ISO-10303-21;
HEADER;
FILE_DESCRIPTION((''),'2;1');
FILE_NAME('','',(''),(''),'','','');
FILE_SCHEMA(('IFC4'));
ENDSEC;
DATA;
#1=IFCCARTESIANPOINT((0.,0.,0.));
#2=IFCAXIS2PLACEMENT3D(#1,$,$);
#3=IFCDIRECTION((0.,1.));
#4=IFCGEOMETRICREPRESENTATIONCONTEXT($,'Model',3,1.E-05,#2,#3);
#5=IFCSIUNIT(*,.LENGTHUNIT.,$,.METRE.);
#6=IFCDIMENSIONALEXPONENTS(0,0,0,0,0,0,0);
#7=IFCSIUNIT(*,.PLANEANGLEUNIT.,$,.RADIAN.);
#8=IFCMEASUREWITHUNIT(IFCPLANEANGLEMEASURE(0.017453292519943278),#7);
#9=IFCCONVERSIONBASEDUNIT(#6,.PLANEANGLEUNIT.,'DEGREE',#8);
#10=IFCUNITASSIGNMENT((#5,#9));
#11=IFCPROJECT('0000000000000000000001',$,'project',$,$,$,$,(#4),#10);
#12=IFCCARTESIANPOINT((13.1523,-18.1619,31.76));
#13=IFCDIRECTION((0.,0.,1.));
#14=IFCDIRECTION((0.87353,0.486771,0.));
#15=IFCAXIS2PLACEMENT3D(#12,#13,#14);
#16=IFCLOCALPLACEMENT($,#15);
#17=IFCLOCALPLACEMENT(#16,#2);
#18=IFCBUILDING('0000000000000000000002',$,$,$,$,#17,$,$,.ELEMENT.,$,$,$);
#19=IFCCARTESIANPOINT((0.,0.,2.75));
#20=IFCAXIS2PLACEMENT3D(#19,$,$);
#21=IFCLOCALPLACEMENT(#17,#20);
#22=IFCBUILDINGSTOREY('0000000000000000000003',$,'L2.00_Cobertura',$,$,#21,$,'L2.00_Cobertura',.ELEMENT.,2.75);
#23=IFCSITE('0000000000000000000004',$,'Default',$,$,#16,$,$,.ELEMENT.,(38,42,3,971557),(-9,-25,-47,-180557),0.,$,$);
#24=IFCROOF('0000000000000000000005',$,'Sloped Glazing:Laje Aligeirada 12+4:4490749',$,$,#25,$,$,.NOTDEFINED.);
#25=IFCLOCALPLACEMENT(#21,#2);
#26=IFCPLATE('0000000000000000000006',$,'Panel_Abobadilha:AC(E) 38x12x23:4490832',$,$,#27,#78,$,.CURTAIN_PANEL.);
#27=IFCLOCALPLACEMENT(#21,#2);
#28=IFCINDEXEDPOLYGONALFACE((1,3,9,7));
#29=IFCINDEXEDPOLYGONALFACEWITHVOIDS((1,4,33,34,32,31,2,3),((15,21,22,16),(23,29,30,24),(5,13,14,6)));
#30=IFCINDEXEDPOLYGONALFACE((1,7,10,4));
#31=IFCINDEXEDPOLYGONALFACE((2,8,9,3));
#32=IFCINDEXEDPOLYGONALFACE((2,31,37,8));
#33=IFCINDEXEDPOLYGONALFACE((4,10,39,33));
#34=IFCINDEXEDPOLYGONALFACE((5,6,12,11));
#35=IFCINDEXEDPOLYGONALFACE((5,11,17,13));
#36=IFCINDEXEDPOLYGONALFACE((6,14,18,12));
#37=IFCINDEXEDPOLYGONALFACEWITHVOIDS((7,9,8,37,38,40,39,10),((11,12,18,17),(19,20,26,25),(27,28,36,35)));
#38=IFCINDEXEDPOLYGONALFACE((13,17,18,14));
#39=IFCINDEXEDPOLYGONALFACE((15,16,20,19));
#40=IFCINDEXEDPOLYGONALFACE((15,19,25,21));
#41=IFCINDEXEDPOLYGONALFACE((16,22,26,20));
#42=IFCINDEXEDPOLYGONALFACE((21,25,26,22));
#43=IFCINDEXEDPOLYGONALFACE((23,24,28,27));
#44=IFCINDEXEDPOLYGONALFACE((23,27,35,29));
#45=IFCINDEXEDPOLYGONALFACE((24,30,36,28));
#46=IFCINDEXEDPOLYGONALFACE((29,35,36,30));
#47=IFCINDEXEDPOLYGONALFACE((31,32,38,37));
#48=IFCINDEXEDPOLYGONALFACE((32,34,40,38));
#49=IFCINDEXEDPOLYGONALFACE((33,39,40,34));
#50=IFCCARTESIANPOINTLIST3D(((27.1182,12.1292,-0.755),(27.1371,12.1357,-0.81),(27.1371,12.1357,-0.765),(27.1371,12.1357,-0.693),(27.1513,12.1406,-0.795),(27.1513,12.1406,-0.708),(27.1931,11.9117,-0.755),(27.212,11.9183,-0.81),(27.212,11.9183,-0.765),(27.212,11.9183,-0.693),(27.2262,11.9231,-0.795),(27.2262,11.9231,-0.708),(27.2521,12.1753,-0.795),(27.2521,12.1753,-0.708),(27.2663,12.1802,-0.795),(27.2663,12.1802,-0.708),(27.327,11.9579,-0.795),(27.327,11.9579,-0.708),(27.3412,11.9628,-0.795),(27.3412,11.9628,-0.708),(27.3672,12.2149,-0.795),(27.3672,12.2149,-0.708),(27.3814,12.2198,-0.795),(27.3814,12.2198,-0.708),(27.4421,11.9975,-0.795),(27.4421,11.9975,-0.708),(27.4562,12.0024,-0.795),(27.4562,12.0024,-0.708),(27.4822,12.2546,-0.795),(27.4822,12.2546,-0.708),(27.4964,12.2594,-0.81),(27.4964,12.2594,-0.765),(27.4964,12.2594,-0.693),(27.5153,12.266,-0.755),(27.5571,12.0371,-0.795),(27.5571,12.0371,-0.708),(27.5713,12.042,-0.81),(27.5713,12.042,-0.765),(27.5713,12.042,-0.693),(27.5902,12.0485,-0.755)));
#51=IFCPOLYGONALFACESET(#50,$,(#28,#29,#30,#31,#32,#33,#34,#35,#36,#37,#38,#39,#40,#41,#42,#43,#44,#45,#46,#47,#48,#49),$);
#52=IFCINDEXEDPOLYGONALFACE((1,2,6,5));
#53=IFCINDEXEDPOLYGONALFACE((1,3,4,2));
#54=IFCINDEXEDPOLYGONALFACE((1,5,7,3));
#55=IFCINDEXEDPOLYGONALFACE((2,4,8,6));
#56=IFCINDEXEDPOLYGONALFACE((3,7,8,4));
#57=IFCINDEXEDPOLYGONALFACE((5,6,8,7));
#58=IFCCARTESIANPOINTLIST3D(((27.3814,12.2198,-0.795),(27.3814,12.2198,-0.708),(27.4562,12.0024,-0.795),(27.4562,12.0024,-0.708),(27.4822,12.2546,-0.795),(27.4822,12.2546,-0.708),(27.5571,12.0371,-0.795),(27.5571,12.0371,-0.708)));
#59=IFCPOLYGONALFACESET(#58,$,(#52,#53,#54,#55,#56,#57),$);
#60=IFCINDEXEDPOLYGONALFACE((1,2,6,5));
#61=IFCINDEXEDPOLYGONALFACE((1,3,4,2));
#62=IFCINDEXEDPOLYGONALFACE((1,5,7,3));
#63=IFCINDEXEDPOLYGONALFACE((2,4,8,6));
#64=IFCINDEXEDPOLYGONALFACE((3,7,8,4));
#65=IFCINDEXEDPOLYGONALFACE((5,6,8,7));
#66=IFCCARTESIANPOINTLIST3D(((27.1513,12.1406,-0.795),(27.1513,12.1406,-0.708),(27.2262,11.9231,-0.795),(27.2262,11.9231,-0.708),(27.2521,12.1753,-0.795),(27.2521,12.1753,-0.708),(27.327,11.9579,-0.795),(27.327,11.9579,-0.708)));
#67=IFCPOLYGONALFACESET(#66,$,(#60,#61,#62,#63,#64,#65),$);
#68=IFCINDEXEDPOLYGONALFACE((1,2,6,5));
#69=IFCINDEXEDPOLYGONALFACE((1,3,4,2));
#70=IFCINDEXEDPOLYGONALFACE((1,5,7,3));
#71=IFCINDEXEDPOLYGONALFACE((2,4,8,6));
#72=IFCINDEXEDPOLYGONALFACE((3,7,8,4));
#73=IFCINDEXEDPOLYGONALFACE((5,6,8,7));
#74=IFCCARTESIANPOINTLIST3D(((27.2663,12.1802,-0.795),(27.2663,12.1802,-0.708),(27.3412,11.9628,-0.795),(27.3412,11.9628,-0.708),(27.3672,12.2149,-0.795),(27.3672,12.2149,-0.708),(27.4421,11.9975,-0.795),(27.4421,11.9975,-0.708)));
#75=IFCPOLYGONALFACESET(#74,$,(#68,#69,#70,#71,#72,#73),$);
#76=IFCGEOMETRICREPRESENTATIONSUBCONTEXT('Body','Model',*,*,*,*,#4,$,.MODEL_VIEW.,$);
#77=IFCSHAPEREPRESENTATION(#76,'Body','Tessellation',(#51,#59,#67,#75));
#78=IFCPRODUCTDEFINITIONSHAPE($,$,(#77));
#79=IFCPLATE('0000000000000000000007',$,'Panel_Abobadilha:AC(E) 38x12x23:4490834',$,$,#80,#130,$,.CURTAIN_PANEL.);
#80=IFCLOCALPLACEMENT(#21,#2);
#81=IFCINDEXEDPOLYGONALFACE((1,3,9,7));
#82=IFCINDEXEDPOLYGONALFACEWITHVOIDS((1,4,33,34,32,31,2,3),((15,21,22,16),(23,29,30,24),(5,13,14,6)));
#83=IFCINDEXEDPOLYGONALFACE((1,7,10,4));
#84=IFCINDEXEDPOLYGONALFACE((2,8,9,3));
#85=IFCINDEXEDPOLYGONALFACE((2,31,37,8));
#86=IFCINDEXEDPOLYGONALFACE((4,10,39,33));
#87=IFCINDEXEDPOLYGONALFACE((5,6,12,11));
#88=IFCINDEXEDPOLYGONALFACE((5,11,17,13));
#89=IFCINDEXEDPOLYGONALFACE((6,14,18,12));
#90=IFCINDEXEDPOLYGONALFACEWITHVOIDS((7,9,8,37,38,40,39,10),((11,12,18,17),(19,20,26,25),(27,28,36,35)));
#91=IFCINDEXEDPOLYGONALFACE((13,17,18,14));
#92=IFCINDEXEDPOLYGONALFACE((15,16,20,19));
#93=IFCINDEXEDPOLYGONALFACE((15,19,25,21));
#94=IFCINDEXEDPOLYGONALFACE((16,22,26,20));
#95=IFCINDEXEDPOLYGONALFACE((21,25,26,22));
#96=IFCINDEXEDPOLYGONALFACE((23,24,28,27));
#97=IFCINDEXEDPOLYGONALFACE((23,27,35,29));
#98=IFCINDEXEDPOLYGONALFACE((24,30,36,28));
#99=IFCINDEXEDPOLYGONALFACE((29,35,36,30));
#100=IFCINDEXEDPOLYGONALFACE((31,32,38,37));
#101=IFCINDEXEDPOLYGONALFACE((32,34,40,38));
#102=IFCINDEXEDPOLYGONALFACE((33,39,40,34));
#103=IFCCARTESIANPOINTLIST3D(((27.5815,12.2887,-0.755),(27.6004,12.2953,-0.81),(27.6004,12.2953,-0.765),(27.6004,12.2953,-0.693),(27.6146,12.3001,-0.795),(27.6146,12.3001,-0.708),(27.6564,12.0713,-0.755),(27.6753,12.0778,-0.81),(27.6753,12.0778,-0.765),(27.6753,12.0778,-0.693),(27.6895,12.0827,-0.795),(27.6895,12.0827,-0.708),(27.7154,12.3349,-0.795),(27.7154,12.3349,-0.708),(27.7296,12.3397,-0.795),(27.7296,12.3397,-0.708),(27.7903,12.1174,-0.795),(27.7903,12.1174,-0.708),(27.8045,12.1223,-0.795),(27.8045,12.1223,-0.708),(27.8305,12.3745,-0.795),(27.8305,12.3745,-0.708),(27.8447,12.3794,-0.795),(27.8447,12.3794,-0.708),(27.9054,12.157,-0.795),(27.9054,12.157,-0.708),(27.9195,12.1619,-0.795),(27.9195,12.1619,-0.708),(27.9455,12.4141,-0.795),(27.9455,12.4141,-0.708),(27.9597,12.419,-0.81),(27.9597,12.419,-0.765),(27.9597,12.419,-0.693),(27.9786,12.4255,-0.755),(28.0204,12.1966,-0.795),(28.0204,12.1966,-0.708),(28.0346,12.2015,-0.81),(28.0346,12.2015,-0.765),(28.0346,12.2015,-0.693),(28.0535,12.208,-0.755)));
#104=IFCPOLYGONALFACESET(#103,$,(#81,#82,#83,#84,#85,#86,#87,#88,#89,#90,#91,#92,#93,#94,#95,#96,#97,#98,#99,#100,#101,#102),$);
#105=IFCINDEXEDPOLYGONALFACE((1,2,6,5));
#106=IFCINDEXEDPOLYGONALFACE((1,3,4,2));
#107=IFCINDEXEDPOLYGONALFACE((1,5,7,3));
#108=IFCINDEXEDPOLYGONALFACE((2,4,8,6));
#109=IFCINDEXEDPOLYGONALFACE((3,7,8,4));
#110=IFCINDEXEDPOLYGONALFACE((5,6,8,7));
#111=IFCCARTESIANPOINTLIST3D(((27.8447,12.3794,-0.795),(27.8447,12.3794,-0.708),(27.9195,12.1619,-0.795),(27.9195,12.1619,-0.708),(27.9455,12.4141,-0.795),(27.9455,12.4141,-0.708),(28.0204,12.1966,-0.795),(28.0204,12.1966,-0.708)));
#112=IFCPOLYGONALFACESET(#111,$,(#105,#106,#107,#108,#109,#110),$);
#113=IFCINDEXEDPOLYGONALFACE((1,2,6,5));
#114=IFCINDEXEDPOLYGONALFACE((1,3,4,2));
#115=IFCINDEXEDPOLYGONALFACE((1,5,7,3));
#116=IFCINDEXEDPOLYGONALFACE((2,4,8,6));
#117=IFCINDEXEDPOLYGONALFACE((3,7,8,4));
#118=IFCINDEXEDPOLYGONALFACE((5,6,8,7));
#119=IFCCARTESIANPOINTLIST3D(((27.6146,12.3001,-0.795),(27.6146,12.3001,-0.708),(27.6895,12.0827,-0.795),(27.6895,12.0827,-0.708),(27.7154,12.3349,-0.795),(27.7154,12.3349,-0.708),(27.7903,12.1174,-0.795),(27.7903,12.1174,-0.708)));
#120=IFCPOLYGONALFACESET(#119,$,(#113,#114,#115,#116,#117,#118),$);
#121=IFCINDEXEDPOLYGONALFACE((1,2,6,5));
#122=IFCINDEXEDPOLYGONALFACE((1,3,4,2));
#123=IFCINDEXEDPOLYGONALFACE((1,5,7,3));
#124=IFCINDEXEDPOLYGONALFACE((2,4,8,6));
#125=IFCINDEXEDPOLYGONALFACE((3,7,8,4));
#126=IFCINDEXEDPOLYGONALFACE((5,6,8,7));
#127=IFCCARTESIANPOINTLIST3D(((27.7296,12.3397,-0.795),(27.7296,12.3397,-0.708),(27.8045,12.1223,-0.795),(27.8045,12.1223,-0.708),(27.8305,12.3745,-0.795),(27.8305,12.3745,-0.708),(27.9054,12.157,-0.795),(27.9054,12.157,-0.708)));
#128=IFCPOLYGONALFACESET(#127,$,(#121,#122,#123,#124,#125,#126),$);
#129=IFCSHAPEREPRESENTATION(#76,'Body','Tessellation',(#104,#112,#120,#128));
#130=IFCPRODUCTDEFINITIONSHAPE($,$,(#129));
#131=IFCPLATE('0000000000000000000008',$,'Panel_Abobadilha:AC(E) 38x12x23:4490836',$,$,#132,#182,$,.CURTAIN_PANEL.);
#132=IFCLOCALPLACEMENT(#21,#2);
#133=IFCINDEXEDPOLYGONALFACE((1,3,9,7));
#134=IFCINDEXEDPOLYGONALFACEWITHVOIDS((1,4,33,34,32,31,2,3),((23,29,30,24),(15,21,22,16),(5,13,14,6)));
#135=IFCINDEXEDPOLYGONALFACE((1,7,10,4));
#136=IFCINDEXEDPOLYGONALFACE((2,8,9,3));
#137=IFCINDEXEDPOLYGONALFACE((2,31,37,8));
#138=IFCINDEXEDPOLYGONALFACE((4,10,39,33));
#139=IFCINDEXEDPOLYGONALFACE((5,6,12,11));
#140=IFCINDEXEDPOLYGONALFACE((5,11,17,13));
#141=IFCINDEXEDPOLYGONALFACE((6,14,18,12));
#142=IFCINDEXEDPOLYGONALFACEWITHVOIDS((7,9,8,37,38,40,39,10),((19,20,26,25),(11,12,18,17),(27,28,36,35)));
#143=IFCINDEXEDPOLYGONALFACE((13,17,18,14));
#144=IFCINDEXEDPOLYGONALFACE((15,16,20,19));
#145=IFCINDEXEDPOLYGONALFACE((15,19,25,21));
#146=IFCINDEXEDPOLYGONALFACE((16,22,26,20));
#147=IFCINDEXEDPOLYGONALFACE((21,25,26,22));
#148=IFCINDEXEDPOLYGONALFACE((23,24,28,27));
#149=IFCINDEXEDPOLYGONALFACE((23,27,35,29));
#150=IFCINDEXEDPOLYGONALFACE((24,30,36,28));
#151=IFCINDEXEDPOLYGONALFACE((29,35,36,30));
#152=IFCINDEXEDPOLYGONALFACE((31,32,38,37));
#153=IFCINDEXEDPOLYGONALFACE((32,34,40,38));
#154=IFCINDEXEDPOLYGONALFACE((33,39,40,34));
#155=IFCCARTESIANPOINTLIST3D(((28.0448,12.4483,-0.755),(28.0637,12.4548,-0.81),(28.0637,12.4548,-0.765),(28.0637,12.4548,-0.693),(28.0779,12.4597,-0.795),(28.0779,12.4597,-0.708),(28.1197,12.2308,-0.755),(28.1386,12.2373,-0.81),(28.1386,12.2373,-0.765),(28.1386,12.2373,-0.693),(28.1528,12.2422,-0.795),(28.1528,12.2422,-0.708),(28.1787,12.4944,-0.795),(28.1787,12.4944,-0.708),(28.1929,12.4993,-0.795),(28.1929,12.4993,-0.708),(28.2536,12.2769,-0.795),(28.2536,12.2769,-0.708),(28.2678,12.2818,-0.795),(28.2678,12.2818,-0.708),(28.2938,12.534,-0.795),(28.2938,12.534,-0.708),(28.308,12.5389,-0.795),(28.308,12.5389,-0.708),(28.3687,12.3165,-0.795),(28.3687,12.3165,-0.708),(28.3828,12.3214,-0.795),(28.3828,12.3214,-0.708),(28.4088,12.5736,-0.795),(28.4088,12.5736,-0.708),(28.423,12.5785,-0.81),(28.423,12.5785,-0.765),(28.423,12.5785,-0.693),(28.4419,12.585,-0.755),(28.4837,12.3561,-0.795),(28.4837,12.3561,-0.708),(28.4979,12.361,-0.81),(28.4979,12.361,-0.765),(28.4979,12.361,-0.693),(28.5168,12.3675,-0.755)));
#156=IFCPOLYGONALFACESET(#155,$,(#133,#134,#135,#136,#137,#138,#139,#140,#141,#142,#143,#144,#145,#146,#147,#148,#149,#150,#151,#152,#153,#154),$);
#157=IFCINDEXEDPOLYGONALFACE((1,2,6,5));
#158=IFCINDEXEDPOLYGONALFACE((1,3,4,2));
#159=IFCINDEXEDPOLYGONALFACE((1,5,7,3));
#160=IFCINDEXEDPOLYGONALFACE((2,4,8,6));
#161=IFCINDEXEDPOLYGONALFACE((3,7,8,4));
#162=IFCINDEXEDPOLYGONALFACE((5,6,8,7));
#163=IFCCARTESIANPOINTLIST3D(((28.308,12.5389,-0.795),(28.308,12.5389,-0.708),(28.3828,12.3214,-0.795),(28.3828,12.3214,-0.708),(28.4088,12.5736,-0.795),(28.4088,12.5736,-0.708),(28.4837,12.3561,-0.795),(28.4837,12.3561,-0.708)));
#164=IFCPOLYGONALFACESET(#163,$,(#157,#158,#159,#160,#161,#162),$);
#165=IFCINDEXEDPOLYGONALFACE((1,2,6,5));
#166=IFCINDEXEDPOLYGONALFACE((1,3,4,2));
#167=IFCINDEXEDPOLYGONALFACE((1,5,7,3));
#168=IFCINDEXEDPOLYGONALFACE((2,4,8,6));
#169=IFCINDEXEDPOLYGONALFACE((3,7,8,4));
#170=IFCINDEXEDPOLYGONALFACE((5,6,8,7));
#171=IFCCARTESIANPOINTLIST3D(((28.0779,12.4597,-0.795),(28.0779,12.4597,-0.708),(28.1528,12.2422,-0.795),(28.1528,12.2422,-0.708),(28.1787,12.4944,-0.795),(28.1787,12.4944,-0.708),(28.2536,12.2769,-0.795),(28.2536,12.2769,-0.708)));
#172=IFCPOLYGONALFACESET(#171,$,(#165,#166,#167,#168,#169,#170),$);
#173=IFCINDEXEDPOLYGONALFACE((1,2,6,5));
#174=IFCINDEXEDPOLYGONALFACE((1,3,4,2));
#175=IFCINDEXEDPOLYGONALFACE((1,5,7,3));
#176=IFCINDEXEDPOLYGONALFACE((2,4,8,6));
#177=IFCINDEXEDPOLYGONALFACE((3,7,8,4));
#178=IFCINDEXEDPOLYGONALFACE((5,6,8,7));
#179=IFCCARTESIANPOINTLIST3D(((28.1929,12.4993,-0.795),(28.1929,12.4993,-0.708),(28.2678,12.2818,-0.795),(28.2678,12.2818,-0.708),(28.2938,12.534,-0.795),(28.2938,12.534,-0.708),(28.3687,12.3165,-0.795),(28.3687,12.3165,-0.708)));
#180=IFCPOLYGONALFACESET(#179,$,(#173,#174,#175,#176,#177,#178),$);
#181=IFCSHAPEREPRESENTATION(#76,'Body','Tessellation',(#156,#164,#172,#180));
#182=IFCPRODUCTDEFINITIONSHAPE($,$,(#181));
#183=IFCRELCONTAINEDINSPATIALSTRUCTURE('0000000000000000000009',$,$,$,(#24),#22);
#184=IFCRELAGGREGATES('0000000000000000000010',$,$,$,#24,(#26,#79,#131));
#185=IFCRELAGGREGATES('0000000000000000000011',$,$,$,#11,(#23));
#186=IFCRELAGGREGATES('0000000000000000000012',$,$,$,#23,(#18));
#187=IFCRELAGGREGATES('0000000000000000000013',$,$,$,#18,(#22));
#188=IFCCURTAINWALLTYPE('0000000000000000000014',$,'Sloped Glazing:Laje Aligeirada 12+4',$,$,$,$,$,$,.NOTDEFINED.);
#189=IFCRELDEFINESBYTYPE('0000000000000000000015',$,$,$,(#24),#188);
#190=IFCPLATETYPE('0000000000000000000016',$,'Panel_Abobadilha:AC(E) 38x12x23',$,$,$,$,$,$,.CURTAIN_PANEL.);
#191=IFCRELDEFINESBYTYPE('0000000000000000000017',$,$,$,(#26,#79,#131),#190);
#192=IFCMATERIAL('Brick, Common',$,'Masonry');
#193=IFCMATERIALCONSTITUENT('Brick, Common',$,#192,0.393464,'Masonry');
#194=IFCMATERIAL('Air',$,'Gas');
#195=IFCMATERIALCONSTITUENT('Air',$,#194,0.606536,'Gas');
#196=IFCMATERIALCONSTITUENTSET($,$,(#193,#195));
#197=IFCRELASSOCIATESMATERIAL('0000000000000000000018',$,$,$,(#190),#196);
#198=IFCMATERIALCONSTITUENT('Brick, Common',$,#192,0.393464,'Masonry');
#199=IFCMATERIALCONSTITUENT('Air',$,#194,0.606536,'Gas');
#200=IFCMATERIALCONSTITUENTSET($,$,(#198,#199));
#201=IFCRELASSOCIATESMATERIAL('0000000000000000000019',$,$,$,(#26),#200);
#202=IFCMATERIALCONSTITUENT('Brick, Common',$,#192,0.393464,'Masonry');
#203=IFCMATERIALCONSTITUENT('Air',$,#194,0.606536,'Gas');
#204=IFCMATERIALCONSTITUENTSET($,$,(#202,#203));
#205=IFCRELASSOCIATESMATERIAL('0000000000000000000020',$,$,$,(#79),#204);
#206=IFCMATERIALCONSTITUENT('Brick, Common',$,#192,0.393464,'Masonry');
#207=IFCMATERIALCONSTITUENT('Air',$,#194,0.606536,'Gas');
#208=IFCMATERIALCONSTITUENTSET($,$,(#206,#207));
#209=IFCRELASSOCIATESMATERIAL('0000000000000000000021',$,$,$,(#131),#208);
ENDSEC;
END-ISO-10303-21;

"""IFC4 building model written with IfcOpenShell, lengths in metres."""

from ifc_helpers import new_model, entity, si_unit, converted_unit, direction, frame, origin, place, context, subcontext, project, spatial, indexed_curve, outline, extrude, source, transform, mapped, material, constituent, constituent_set, type_object, type_shapes, element, aggregate, save


model = new_model("IFC4")

# Units and contexts
model_context = context("Model", 3, precision=1e-05, world=origin(), true_north=direction((0.0, 1.0)))
body_context = subcontext(model_context, "Body", "Model", "MODEL_VIEW")
ifc_project = project(units=[si_unit("LENGTHUNIT", "METRE"), converted_unit("PLANEANGLEUNIT", "DEGREE", entity("IfcPlaneAngleMeasure", 0.017453292519943278), si_unit("PLANEANGLEUNIT", "RADIAN"), dimensions=[0, 0, 0, 0, 0, 0, 0])], contexts=[model_context])

# Site, building, storey
site_placement = place(None, frame((13.1523, -18.1619, 31.76), z_axis=(0.0, 0.0, 1.0), x_axis=(0.87353, 0.486771, 0.0)))
site = spatial("IfcSite", under=ifc_project, at=site_placement, Name="Default", CompositionType="ELEMENT", RefLatitude=(38, 42, 3, 971557), RefLongitude=(-9, -25, -47, -180557), RefElevation=0.0)
building_placement = place(site_placement, origin())
building = spatial("IfcBuilding", under=site, at=building_placement, CompositionType="ELEMENT")
storey_placement = place(building_placement, frame((0.0, 0.0, 2.75)))
storey = spatial("IfcBuildingStorey", under=building, at=storey_placement, Name="L2.00_Cobertura", LongName="L2.00_Cobertura", CompositionType="ELEMENT", Elevation=2.75)

# Roof, plates
curtain_wall_type = type_object("IfcCurtainWallType", Name="Sloped Glazing:Laje Aligeirada 12+4", PredefinedType="NOTDEFINED")
roof_placement = place(storey_placement, frame((0.0, 0.0, -2.75)))
roof = element("IfcRoof", 1, at=roof_placement, inside=storey, type_object=curtain_wall_type, Name="Sloped Glazing:Laje Aligeirada 12+4:4490749", PredefinedType="NOTDEFINED")
ifc_material_1 = material(Name="Brick, Common", Category="Masonry")
ifc_constituent_1 = constituent(ifc_material_1, Name="Brick, Common", Category="Masonry", fraction=0.393464)
ifc_material_2 = material(Name="Air", Category="Gas")
ifc_constituent_2 = constituent(ifc_material_2, Name="Air", Category="Gas", fraction=0.606536)
ifc_constituent_set_1 = constituent_set(constituents=[ifc_constituent_1, ifc_constituent_2])
ifc_constituent_3 = constituent(ifc_material_1, Name="Brick, Common", Category="Masonry", fraction=0.393464)
ifc_constituent_4 = constituent(ifc_material_2, Name="Air", Category="Gas", fraction=0.606536)
ifc_constituent_set_2 = constituent_set(constituents=[ifc_constituent_3, ifc_constituent_4])
plate_type_1 = type_object("IfcPlateType", Name="Panel_Abobadilha:AC(E) 38x12x23", PredefinedType="CURTAIN_PANEL", material=ifc_constituent_set_2)
shared_shape_1 = source(origin(), body_context, "Body", "SweptSolid", [
    extrude(outline(indexed_curve([(-0.19, -0.0543), (0.19, -0.0543), (0.19, -0.0093), (0.21, 0.0007), (0.19, 0.0628), (-0.19, 0.0628), (-0.21, 0.0007), (-0.19, -0.0093), (-0.19, -0.0543)], self_intersect=False), holes=[indexed_curve([(-0.0683, 0.0477), (-0.0683, -0.0393), (-0.175, -0.0393), (-0.175, 0.0477), (-0.0683, 0.0477)], self_intersect=False), indexed_curve([(0.0533, 0.0477), (0.0533, -0.0393), (-0.0533, -0.0393), (-0.0533, 0.0477), (0.0533, 0.0477)], self_intersect=False), indexed_curve([(0.175, 0.0477), (0.175, -0.0393), (0.0683, -0.0393), (0.0683, 0.0477), (0.175, 0.0477)], self_intersect=False)]), frame((0.0, 0.0543, 0.0)), (0.0, 0.0, 1.0), 0.23),
    extrude(outline(indexed_curve([(-0.0533, -0.0435), (0.0533, -0.0435), (0.0533, 0.0435), (-0.0533, 0.0435), (-0.0533, -0.0435)], self_intersect=False)), frame((0.1217, 0.0585, 0.0), z_axis=(0.0, 0.0, 1.0), x_axis=(-1.0, 0.0, 0.0)), (0.0, 0.0, 1.0), 0.23),
    extrude(outline(indexed_curve([(-0.0533, -0.0435), (0.0533, -0.0435), (0.0533, 0.0435), (-0.0533, 0.0435), (-0.0533, -0.0435)], self_intersect=False)), frame((-0.1217, 0.0585, 0.0), z_axis=(0.0, 0.0, 1.0), x_axis=(-1.0, 0.0, 0.0)), (0.0, 0.0, 1.0), 0.23),
    extrude(outline(indexed_curve([(-0.0533, -0.0435), (0.0533, -0.0435), (0.0533, 0.0435), (-0.0533, 0.0435), (-0.0533, -0.0435)], self_intersect=False)), frame((0.0, 0.0585, 0.0), z_axis=(0.0, 0.0, 1.0), x_axis=(-1.0, 0.0, 0.0)), (0.0, 0.0, 1.0), 0.23),
])
type_shapes(plate_type_1, [shared_shape_1])
plate_1_placement = place(roof_placement, frame((27.3168, 12.1976, 1.94), z_axis=(0.325568, -0.945519, 0.0), x_axis=(0.945519, 0.325568, 0.0)))
plate_1 = element("IfcPlate", 2, at=plate_1_placement, type_object=plate_type_1, material=ifc_constituent_set_1, Name="Panel_Abobadilha:AC(E) 38x12x23:4490832", PredefinedType="CURTAIN_PANEL", context=body_context, shape_type="MappedRepresentation", body=[
    mapped(shared_shape_1, transform((0.0, 0.0, 0.0), scale=1.0)),
])
ifc_constituent_5 = constituent(ifc_material_1, Name="Brick, Common", Category="Masonry", fraction=0.393464)
ifc_constituent_6 = constituent(ifc_material_2, Name="Air", Category="Gas", fraction=0.606536)
ifc_constituent_set_3 = constituent_set(constituents=[ifc_constituent_5, ifc_constituent_6])
plate_2_placement = place(roof_placement, frame((27.7801, 12.3571, 1.94), z_axis=(0.325568, -0.945519, 0.0), x_axis=(0.945519, 0.325568, 0.0)))
plate_2 = element("IfcPlate", 3, at=plate_2_placement, type_object=plate_type_1, material=ifc_constituent_set_3, Name="Panel_Abobadilha:AC(E) 38x12x23:4490834", PredefinedType="CURTAIN_PANEL", context=body_context, shape_type="MappedRepresentation", body=[
    mapped(shared_shape_1, transform((0.0, 0.0, 0.0), scale=1.0)),
])
ifc_constituent_7 = constituent(ifc_material_1, Name="Brick, Common", Category="Masonry", fraction=0.393464)
ifc_constituent_8 = constituent(ifc_material_2, Name="Air", Category="Gas", fraction=0.606536)
ifc_constituent_set_4 = constituent_set(constituents=[ifc_constituent_7, ifc_constituent_8])
plate_3_placement = place(roof_placement, frame((28.2434, 12.5166, 1.94), z_axis=(0.325568, -0.945519, 0.0), x_axis=(0.945519, 0.325568, 0.0)))
plate_3 = element("IfcPlate", 4, at=plate_3_placement, type_object=plate_type_1, material=ifc_constituent_set_4, Name="Panel_Abobadilha:AC(E) 38x12x23:4490836", PredefinedType="CURTAIN_PANEL", context=body_context, shape_type="MappedRepresentation", body=[
    mapped(shared_shape_1, transform((0.0, 0.0, 0.0), scale=1.0)),
])
aggregate(roof, [plate_1, plate_2, plate_3])

save(model, "model.ifc")
